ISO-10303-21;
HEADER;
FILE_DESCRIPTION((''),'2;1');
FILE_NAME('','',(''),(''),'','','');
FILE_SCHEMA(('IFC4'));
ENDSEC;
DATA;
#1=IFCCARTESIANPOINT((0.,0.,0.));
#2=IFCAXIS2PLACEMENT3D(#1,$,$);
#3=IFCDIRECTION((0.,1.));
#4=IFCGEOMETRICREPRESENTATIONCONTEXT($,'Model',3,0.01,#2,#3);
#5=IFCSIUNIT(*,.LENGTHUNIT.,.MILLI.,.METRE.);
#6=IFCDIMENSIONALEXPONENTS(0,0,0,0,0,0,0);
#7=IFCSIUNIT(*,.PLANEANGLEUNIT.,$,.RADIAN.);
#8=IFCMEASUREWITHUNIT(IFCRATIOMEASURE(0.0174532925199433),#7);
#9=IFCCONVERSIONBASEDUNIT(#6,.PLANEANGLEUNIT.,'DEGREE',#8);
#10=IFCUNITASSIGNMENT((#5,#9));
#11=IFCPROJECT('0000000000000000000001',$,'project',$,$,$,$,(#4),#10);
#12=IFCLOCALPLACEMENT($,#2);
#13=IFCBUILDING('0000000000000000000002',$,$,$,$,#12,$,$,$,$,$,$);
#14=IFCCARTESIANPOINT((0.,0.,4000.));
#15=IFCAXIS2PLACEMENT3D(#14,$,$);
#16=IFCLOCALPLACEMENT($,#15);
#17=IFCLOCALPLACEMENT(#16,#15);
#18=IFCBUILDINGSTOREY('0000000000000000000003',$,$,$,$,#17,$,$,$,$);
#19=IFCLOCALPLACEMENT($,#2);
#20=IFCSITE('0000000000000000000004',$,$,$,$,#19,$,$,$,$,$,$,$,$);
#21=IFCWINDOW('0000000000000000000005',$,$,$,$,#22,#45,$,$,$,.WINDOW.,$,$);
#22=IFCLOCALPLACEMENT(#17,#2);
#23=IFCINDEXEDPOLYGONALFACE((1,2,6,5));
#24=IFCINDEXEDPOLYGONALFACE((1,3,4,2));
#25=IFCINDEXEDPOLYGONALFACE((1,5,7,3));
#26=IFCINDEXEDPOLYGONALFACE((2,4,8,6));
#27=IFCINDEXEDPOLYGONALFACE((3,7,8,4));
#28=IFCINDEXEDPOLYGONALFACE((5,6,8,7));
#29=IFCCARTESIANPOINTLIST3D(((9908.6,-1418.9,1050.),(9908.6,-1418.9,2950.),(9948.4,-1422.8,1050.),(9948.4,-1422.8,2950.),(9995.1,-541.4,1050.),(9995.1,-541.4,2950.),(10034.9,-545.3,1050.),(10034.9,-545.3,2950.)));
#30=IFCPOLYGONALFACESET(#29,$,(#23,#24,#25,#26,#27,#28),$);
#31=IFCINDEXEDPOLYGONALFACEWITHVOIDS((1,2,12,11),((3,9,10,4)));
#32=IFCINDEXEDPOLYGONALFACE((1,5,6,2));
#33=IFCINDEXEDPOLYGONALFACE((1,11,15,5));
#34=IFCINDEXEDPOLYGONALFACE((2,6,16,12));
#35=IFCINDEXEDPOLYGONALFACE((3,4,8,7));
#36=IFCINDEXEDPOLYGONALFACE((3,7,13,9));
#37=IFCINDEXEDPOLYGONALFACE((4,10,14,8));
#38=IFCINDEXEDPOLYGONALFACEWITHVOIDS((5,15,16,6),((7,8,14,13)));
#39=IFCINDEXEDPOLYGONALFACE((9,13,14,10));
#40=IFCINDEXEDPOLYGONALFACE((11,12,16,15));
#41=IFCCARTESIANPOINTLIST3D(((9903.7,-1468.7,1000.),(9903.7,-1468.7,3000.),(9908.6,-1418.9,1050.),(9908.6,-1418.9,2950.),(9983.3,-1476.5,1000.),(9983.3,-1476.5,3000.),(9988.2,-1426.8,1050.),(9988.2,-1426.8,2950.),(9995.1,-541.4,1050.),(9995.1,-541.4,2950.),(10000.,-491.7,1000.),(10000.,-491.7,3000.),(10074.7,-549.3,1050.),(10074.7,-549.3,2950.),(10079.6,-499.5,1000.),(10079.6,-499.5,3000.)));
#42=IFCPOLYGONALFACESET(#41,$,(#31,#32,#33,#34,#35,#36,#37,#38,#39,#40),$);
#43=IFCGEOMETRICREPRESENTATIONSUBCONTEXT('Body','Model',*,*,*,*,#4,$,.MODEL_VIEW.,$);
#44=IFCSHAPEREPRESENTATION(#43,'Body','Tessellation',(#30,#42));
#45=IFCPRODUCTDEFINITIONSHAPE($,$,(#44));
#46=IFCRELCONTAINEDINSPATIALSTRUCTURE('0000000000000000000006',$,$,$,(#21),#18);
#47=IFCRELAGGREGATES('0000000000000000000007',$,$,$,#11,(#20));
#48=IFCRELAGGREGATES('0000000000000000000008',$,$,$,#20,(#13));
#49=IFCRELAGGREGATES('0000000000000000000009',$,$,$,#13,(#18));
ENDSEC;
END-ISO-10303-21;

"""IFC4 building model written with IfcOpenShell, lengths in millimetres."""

from ifc_helpers import new_model, entity, si_unit, converted_unit, direction, frame, origin, place, context, subcontext, project, spatial, element, save


model = new_model("IFC4")

# Units and contexts
model_context = context("Model", 3, precision=0.01, world=origin(), true_north=direction((0.0, 1.0)))
body_context = subcontext(model_context, "Body", "Model", "MODEL_VIEW")
ifc_project = project(units=[si_unit("LENGTHUNIT", "METRE", prefix="MILLI"), converted_unit("PLANEANGLEUNIT", "DEGREE", entity("IfcRatioMeasure", 0.0174532925199433), si_unit("PLANEANGLEUNIT", "RADIAN"), dimensions=[0, 0, 0, 0, 0, 0, 0])], contexts=[model_context])

# Site, building, storey
site_placement = place(None, origin())
site = spatial("IfcSite", under=ifc_project, at=site_placement)
building_placement = place(None, origin())
building = spatial("IfcBuilding", under=site, at=building_placement)
placement = place(None, frame((0.0, 0.0, 4000.0)))
storey_placement = place(placement, frame((0.0, 0.0, 4000.0)))
storey = spatial("IfcBuildingStorey", under=building, at=storey_placement)

# Shared definitions
cartesian_point_1 = entity("IfcCartesianPoint", [-440.9, -950.0])
shared_polyline = entity("IfcPolyline", [cartesian_point_1, entity("IfcCartesianPoint", [-440.9, 950.0]), entity("IfcCartesianPoint", [-440.9, 950.0]), entity("IfcCartesianPoint", [440.9, 950.0]), entity("IfcCartesianPoint", [440.9, 950.0]), entity("IfcCartesianPoint", [440.9, -950.0]), entity("IfcCartesianPoint", [440.9, -950.0]), entity("IfcCartesianPoint", [-440.9, -950.0]), cartesian_point_1])

# Window
window_1_placement = place(storey_placement, frame((9951.8, -980.2, 2000.0), z_axis=(0.0, 0.0, 1.0), x_axis=(980.172434, 9951.847165, 0.0)))
cartesian_point_2 = entity("IfcCartesianPoint", [-490.9, -1000.0])
element("IfcWindow", 1, at=window_1_placement, inside=storey, PredefinedType="WINDOW", context=body_context, shape_type="SweptSolid", body=[
    entity("IfcExtrudedAreaSolid", entity("IfcArbitraryClosedProfileDef", "AREA", None, shared_polyline), entity("IfcAxis2Placement3D", entity("IfcCartesianPoint", [0.0, 0.0, 0.0]), entity("IfcDirection", [0.0, -1.0, 0.0]), entity("IfcDirection", [1.0, 0.0, 0.0])), entity("IfcDirection", [0.0, 0.0, 1.0]), 40.0),
    entity("IfcExtrudedAreaSolid", entity("IfcArbitraryProfileDefWithVoids", "AREA", None, entity("IfcPolyline", [cartesian_point_2, entity("IfcCartesianPoint", [-490.9, 1000.0]), entity("IfcCartesianPoint", [-490.9, 1000.0]), entity("IfcCartesianPoint", [490.9, 1000.0]), entity("IfcCartesianPoint", [490.9, 1000.0]), entity("IfcCartesianPoint", [490.9, -1000.0]), entity("IfcCartesianPoint", [490.9, -1000.0]), entity("IfcCartesianPoint", [-490.9, -1000.0]), cartesian_point_2]), [shared_polyline]), entity("IfcAxis2Placement3D", entity("IfcCartesianPoint", [0.0, 0.0, 0.0]), entity("IfcDirection", [0.0, -1.0, 0.0]), entity("IfcDirection", [1.0, 0.0, 0.0])), entity("IfcDirection", [0.0, 0.0, 1.0]), 80.0),
])

save(model, "model.ifc")
